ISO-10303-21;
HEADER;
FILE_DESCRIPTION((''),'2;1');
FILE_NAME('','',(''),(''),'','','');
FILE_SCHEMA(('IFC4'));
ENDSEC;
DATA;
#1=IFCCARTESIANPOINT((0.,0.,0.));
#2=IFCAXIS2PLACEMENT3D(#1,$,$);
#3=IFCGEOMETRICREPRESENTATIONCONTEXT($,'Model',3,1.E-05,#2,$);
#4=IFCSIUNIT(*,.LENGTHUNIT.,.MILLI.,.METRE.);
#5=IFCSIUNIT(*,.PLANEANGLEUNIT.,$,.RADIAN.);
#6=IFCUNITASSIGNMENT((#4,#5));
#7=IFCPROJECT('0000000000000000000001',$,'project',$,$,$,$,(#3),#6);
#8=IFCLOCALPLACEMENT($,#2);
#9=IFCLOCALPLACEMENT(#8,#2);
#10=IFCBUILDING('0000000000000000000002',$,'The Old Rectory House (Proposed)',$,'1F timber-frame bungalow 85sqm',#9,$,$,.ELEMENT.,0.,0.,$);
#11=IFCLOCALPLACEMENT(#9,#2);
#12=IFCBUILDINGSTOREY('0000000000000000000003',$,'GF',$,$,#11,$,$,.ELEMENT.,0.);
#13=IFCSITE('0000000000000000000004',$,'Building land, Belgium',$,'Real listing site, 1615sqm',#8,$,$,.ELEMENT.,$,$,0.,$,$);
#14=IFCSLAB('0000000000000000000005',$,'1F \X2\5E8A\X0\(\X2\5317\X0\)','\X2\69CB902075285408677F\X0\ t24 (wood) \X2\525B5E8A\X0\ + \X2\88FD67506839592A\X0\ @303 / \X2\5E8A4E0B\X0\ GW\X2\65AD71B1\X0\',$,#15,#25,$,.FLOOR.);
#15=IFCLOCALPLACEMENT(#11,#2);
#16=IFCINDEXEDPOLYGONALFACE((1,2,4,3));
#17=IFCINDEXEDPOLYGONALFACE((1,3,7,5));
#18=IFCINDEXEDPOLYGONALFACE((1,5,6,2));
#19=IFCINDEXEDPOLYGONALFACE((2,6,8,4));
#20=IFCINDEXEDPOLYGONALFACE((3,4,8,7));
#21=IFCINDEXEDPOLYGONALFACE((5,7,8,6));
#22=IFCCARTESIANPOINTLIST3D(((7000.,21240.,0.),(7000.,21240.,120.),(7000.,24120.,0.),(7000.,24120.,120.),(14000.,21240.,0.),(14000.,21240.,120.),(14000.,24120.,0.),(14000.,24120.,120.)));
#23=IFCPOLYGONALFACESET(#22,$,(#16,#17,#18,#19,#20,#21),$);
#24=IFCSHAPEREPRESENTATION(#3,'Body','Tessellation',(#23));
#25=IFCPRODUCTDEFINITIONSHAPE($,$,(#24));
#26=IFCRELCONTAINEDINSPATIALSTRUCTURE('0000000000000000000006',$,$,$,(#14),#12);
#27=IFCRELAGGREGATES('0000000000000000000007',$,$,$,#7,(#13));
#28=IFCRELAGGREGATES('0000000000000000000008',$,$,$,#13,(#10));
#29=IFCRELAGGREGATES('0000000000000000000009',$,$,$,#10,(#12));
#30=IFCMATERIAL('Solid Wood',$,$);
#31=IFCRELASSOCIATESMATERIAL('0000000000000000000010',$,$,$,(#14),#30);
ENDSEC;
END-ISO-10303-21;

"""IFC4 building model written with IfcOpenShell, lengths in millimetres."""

from ifc_helpers import new_model, si_unit, frame, frame_2d, origin, place, context, project, spatial, rectangle, extrude, material, element, save


model = new_model("IFC4")

# Units and contexts
model_context = context("Model", 3, precision=1e-05, world=origin())
ifc_project = project(units=[si_unit("LENGTHUNIT", "METRE", prefix="MILLI"), si_unit("PLANEANGLEUNIT", "RADIAN")], contexts=[model_context])

# Site, building, storey
site_placement = place(None, origin())
site = spatial("IfcSite", under=ifc_project, at=site_placement, Name="Building land, Belgium", ObjectType="Real listing site, 1615sqm", CompositionType="ELEMENT", RefElevation=0.0)
building_placement = place(site_placement, origin())
building = spatial("IfcBuilding", under=site, at=building_placement, Name="The Old Rectory House (Proposed)", ObjectType="1F timber-frame bungalow 85sqm", CompositionType="ELEMENT", ElevationOfRefHeight=0.0, ElevationOfTerrain=0.0)
storey_placement = place(building_placement, origin())
storey = spatial("IfcBuildingStorey", under=building, at=storey_placement, Name="GF", CompositionType="ELEMENT", Elevation=0.0)

# Slab
ifc_material_1 = material(Name="Solid Wood")
slab_1_placement = place(storey_placement, frame((3500.0, 10620.0, 0.0)))
element("IfcSlab", 1, at=slab_1_placement, inside=storey, material=ifc_material_1, Name="1F 床(北)", Description="構造用合板 t24 (wood) 剛床 + 製材根太 @303 / 床下 GW断熱", PredefinedType="FLOOR", context=model_context, shape_type="SweptSolid", body=[
    extrude(rectangle(XDim=7000.0, YDim=2880.0, at=frame_2d((3500.0, 1440.0))), frame((3500.0, 10620.0, 0.0)), (0.0, 0.0, 1.0), 120.0),
])

save(model, "model.ifc")
